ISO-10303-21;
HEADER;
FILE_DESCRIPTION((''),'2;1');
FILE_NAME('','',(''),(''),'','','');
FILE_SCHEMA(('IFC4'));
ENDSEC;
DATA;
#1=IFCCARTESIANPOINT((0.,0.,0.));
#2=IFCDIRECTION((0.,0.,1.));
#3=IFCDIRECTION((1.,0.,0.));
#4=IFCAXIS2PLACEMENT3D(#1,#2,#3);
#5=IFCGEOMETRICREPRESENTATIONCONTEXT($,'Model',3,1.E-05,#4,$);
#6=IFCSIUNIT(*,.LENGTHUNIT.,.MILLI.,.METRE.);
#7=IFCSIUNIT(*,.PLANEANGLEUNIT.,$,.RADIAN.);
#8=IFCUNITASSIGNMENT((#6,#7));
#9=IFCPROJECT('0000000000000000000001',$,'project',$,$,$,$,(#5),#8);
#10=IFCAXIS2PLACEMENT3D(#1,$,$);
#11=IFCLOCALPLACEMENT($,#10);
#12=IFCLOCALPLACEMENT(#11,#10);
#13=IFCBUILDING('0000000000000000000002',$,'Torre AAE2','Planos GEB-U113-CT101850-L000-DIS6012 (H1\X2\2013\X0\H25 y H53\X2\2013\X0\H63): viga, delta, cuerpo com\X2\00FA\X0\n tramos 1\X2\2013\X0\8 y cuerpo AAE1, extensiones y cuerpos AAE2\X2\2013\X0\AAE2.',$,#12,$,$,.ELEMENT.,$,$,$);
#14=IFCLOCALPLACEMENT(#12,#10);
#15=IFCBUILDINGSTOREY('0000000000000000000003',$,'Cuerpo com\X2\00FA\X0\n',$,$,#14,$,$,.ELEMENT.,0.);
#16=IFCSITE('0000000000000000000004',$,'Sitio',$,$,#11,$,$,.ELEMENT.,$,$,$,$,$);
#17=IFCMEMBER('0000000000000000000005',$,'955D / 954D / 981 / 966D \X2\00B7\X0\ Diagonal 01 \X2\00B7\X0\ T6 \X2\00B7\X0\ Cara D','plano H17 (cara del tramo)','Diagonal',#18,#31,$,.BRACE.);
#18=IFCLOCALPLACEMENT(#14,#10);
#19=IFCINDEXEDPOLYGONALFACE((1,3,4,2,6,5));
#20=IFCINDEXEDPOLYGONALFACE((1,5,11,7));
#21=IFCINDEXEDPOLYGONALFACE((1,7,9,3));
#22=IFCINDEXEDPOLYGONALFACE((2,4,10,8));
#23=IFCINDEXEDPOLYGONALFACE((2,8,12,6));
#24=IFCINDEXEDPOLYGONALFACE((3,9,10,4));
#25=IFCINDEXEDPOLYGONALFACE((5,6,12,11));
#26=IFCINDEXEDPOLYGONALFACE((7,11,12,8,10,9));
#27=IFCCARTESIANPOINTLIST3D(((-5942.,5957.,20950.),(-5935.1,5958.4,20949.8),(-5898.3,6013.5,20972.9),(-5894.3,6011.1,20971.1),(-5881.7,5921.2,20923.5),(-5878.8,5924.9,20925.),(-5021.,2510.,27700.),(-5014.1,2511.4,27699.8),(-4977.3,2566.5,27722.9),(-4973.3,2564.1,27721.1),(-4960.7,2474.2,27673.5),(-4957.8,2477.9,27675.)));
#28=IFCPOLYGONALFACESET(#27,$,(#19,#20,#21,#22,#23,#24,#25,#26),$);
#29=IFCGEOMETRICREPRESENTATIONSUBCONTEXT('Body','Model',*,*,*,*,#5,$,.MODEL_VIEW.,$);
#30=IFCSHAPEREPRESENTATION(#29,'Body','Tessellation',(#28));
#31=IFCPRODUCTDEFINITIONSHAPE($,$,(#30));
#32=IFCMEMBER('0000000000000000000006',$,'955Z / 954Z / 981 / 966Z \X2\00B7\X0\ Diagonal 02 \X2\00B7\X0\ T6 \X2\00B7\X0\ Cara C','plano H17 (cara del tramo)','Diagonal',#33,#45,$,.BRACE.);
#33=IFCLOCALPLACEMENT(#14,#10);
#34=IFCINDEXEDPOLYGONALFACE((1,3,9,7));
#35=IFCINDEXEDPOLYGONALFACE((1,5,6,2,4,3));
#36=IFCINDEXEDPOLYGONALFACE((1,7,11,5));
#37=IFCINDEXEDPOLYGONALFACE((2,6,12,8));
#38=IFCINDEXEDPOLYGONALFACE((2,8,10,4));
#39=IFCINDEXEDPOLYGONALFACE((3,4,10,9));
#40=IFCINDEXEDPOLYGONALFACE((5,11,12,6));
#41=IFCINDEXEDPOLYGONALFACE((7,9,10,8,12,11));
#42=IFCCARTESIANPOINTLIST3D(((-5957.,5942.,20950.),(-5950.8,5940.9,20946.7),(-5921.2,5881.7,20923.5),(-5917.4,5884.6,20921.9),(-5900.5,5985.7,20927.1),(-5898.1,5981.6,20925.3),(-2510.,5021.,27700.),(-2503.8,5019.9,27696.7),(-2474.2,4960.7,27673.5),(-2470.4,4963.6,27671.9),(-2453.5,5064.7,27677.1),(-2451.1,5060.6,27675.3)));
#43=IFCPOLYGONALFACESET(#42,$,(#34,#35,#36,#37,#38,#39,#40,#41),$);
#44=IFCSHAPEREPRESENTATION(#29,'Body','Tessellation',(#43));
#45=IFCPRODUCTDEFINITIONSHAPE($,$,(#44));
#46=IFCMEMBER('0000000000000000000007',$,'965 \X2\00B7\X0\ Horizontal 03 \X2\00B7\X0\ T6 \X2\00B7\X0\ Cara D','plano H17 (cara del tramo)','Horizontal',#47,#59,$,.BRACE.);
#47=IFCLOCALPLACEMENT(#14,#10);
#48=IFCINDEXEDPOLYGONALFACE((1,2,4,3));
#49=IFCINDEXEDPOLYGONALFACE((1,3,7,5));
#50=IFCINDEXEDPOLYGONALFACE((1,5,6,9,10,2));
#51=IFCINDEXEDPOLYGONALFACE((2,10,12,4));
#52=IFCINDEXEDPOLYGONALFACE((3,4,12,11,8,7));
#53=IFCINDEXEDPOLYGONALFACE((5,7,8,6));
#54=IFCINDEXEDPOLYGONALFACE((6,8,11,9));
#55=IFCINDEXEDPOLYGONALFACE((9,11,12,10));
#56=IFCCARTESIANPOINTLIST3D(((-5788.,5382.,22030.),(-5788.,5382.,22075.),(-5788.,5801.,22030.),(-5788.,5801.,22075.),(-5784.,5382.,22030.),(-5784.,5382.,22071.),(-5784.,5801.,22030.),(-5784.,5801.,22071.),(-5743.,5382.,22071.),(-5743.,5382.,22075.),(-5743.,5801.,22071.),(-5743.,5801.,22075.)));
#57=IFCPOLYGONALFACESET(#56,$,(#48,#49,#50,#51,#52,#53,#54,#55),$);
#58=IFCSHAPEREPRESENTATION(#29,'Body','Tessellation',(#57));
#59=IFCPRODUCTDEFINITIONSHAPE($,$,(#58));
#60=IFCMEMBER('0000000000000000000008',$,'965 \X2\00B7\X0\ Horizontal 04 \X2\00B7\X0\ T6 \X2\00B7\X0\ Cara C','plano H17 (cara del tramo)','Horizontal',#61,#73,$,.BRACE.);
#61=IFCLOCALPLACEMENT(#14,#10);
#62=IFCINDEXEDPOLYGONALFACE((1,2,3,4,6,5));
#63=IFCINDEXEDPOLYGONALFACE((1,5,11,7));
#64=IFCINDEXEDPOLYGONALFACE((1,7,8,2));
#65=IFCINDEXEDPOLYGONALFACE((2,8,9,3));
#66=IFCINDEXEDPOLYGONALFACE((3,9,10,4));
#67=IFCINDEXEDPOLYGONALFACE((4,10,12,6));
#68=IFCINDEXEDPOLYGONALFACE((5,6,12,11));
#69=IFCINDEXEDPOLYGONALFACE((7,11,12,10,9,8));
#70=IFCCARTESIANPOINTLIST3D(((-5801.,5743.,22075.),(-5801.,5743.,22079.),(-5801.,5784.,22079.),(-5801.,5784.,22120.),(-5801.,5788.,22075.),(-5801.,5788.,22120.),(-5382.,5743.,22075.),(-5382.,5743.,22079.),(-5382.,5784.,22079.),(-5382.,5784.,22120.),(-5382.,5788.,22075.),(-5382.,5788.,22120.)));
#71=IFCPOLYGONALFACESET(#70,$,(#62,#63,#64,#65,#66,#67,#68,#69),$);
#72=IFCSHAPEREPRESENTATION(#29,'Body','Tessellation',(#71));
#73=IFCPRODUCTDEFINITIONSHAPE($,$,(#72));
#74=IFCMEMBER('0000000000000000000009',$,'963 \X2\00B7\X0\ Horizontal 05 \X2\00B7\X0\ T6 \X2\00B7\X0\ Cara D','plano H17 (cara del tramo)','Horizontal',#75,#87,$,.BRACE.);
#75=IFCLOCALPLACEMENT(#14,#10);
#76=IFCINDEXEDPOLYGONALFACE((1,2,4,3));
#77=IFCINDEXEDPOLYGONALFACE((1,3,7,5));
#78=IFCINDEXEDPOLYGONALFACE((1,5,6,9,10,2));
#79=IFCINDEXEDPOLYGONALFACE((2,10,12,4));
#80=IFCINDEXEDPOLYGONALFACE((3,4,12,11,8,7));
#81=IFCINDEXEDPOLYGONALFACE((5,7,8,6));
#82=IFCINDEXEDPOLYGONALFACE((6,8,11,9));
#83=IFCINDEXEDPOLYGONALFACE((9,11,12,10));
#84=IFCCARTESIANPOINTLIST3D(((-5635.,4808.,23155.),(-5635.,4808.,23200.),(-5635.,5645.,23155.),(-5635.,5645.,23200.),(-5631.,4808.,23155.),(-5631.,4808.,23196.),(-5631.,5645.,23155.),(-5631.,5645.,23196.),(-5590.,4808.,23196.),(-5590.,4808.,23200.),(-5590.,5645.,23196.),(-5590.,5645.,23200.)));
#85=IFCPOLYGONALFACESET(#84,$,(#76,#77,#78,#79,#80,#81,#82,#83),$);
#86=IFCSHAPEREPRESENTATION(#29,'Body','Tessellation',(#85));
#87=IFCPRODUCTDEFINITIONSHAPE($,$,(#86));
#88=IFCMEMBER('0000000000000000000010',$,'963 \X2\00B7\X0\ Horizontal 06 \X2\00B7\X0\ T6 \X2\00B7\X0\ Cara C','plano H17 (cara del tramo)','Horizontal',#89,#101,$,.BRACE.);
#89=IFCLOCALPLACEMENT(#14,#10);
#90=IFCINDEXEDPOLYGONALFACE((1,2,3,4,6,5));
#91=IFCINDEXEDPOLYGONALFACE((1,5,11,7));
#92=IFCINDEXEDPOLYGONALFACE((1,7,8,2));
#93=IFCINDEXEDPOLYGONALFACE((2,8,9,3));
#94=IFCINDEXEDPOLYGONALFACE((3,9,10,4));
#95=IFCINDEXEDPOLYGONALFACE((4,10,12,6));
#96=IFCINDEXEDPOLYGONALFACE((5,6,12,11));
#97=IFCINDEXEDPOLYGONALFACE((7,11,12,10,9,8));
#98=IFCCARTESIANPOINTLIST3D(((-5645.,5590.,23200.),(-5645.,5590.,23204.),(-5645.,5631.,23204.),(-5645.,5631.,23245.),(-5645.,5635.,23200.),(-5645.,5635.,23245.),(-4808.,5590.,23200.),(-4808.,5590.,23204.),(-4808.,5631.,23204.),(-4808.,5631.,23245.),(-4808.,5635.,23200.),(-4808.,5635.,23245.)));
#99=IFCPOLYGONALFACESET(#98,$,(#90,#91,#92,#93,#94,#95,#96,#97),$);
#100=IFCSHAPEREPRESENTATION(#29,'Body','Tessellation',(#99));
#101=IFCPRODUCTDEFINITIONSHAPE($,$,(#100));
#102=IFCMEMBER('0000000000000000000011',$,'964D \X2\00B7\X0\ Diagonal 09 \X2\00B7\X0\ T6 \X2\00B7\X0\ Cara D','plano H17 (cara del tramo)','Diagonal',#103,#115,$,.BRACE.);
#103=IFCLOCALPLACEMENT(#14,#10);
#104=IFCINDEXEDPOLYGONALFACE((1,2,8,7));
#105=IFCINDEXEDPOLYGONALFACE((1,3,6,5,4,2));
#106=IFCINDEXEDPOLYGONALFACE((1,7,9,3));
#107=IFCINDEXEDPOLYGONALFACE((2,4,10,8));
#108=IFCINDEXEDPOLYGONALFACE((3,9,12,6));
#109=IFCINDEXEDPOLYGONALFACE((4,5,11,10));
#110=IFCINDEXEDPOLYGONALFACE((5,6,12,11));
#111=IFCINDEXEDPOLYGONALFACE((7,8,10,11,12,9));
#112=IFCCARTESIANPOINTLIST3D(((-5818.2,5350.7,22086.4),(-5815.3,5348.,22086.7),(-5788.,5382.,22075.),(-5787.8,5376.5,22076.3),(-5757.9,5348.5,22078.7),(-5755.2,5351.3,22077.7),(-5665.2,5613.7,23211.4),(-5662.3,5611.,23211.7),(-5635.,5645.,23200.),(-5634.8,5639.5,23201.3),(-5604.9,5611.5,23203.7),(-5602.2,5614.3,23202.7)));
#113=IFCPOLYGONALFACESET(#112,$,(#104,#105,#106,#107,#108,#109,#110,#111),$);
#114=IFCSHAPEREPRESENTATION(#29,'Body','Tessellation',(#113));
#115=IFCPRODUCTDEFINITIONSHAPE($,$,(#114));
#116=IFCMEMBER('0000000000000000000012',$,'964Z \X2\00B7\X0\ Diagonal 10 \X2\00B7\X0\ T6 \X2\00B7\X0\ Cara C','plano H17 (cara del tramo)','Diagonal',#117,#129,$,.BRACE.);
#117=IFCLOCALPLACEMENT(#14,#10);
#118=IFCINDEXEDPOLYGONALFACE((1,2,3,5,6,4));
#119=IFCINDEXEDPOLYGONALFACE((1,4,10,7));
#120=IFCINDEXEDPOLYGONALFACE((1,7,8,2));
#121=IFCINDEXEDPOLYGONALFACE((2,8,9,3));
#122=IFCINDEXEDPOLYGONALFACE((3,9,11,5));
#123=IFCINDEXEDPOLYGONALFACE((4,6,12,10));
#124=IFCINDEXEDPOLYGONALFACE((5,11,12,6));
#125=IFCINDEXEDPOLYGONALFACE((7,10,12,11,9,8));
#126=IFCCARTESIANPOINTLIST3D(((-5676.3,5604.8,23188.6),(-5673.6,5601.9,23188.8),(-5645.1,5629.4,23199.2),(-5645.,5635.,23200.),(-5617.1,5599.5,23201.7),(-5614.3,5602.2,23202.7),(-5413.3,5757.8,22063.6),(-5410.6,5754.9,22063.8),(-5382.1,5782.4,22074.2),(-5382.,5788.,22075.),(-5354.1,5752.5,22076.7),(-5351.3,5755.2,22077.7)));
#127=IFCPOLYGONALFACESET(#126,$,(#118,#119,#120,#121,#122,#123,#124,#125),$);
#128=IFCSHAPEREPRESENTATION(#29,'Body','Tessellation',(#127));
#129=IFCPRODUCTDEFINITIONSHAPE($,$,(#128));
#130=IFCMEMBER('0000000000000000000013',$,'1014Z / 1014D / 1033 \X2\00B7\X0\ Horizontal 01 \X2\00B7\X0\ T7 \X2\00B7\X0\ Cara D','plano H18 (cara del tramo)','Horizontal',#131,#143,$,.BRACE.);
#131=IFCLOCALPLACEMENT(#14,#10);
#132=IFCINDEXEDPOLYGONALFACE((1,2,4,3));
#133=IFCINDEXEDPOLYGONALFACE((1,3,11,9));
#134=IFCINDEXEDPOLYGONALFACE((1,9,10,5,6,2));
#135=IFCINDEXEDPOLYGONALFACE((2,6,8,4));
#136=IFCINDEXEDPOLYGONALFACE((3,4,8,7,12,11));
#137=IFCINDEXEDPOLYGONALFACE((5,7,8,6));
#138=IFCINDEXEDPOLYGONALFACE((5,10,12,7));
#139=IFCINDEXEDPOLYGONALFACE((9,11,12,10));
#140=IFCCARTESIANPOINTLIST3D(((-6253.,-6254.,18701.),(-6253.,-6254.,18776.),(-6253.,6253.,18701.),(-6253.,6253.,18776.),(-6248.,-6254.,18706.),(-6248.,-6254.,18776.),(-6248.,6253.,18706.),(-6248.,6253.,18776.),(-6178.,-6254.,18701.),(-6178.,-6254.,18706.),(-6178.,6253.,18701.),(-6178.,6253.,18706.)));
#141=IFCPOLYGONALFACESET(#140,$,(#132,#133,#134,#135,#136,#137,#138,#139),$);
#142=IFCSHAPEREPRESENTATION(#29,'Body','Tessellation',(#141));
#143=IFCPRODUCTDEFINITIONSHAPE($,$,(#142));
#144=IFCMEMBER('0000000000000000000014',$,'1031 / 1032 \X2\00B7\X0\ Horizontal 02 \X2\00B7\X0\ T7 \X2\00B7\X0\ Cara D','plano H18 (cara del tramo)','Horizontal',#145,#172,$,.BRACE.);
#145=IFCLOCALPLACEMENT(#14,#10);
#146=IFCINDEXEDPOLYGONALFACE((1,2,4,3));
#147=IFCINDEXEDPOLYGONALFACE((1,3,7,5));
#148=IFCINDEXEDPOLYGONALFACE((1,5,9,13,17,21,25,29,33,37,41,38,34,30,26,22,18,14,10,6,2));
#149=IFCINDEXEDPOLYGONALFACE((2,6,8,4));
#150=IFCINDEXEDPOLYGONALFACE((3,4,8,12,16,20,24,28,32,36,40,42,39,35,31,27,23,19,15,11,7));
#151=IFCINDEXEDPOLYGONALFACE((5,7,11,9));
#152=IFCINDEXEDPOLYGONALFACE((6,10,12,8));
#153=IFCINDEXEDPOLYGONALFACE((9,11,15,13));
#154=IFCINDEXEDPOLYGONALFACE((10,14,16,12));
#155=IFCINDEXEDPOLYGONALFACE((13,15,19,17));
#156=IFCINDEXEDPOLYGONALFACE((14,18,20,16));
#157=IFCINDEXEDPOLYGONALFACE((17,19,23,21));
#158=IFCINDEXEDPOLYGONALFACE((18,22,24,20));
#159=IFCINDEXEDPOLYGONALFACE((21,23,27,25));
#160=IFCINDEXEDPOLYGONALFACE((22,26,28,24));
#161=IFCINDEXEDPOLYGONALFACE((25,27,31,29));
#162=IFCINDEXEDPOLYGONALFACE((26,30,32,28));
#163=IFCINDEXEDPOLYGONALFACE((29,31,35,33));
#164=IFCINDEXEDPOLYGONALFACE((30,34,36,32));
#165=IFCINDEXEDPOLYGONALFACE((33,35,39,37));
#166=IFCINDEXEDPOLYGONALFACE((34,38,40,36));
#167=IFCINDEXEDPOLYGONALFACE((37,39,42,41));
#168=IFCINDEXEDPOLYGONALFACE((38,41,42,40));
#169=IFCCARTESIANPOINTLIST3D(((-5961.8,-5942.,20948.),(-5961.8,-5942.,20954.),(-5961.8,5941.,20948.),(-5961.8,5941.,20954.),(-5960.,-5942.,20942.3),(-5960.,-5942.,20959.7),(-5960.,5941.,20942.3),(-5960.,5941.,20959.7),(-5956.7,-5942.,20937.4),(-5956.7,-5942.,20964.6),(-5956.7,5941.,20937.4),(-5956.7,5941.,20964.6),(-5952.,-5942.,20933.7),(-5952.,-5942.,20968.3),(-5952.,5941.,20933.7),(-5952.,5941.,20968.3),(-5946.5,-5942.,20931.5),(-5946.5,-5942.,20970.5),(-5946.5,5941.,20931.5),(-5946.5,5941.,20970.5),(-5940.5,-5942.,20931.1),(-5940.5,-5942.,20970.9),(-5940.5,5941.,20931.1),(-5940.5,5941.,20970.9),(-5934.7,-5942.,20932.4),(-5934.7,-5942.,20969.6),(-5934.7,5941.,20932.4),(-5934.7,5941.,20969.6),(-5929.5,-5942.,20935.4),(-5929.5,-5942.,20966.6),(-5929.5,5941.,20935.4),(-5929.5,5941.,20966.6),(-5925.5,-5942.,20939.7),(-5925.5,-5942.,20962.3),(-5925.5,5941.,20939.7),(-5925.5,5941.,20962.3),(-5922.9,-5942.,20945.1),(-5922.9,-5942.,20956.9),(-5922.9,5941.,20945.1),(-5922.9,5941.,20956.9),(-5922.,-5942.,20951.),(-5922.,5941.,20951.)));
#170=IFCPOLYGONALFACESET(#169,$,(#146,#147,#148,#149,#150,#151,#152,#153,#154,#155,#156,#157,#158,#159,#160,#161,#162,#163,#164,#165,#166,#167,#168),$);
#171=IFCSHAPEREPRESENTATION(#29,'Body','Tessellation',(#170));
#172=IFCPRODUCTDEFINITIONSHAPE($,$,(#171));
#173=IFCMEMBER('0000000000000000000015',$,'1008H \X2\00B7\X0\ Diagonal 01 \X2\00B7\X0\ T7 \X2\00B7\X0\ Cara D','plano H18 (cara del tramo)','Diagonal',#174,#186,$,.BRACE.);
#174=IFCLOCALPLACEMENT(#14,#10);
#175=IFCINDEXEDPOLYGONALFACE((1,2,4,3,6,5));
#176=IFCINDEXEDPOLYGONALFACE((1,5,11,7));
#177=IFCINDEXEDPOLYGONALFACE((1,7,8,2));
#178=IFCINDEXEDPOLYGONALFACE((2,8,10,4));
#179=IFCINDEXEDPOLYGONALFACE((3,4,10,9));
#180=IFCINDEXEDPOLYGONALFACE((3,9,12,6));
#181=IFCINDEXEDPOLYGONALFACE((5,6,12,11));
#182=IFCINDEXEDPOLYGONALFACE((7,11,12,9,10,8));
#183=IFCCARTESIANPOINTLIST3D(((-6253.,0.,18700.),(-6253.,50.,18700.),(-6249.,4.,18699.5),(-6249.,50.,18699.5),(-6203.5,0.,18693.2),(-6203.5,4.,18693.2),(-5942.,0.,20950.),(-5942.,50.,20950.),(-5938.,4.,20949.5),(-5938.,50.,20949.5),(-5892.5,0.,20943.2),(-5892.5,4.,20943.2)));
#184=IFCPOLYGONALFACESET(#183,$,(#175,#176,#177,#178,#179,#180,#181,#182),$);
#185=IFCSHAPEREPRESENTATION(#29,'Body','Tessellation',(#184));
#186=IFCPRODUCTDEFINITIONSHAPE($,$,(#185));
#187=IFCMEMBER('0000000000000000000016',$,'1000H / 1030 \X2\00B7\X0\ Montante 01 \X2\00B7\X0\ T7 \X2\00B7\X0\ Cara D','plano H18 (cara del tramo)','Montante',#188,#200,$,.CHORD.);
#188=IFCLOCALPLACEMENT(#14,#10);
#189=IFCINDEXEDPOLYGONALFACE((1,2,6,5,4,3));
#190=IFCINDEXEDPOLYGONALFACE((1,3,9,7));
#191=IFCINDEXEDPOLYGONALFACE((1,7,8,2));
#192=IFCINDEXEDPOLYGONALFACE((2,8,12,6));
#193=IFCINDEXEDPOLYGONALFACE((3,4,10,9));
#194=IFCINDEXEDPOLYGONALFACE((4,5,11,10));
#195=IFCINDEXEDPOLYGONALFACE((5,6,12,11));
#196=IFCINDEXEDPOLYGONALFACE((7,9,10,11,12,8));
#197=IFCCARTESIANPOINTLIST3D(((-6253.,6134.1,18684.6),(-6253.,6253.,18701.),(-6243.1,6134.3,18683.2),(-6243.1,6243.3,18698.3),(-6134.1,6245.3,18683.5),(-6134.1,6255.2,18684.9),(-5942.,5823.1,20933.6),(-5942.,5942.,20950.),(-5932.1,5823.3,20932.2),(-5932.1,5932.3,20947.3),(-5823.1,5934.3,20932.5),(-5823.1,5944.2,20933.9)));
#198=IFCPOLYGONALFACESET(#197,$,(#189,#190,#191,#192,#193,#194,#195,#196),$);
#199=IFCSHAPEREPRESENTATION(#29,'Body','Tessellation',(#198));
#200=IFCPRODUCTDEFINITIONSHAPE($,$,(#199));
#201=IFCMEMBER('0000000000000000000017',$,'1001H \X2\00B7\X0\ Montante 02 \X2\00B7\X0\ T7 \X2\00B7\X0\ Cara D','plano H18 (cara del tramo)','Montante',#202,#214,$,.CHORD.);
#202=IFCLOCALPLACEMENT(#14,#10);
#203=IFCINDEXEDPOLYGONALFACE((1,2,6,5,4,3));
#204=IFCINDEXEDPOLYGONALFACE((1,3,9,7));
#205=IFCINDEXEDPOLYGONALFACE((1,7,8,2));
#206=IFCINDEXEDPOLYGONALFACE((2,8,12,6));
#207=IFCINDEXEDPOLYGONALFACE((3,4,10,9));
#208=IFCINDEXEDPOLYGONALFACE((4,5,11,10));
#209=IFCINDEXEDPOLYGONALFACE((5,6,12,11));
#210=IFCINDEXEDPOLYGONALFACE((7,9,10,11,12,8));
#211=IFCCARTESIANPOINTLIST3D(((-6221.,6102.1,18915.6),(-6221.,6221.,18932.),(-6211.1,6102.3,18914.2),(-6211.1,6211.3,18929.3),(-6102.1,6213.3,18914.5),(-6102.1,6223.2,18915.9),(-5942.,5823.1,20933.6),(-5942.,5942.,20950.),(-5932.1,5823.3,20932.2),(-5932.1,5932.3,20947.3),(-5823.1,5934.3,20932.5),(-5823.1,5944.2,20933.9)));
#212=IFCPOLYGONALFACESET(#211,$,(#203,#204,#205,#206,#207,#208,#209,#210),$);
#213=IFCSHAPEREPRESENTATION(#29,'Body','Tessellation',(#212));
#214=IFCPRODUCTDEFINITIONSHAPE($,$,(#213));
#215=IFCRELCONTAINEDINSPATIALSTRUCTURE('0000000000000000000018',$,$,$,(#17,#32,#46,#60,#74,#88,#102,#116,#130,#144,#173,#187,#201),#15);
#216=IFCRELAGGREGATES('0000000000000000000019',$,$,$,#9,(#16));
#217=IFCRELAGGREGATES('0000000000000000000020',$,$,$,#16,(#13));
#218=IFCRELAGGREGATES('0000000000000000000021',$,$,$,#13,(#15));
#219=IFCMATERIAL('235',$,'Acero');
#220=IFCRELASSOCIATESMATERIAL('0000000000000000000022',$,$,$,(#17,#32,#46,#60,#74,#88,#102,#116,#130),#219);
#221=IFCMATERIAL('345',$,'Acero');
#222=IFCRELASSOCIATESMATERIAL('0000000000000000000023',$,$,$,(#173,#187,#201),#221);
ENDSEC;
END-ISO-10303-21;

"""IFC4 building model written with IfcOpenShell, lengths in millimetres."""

from ifc_helpers import new_model, si_unit, frame, frame_2d, origin, origin_with_axes, place, context, subcontext, project, spatial, circle, l_section, extrude, material, element, save


model = new_model("IFC4")

# Units and contexts
model_context = context("Model", 3, precision=1e-05, world=origin_with_axes())
body_context = subcontext(model_context, "Body", "Model", "MODEL_VIEW")
ifc_project = project(units=[si_unit("LENGTHUNIT", "METRE", prefix="MILLI"), si_unit("PLANEANGLEUNIT", "RADIAN")], contexts=[model_context])

# Site, building, storey
site_placement = place(None, origin())
site = spatial("IfcSite", under=ifc_project, at=site_placement, Name="Sitio", CompositionType="ELEMENT")
building_placement = place(site_placement, origin())
building = spatial("IfcBuilding", under=site, at=building_placement, Name="Torre AAE2", Description="Planos GEB-U113-CT101850-L000-DIS6012 (H1–H25 y H53–H63): viga, delta, cuerpo común tramos 1–8 y cuerpo AAE1, extensiones y cuerpos AAE2–AAE2.", CompositionType="ELEMENT")
storey_placement = place(building_placement, origin())
storey = spatial("IfcBuildingStorey", under=building, at=storey_placement, Name="Cuerpo común", CompositionType="ELEMENT", Elevation=0.0)

# Members
ifc_material_1 = material(Name="235", Category="Acero")
for number, where, z_axis, x_axis, name in (
    (1, (-5942.0, 5957.0, 20950.0), (0.120629, -0.451476, 0.884092), (0.804164, -0.477732, -0.353685), "955D / 954D / 981 / 966D · Diagonal 01 · T6 · Cara D"),
    (2, (-5957.0, 5942.0, 20950.0), (0.451476, -0.120629, 0.884092), (0.477732, -0.804164, -0.353685), "955Z / 954Z / 981 / 966Z · Diagonal 02 · T6 · Cara C"),
):
    element("IfcMember", number, at=place(storey_placement, frame(where, z_axis=z_axis, x_axis=x_axis)), inside=storey, material=ifc_material_1, Name=name, Description="plano H17 (cara del tramo)", ObjectType="Diagonal", PredefinedType="BRACE", context=body_context, shape_type="SweptSolid", body=[
        extrude(l_section(Depth=75.0, Width=75.0, Thickness=5.0, at=frame_2d((37.5, 37.5))), None, (0.0, 0.0, 1.0), 7635.0),
    ])
for number, where, z_axis, x_axis, name in (
    (3, (-5788.0, 5382.0, 22075.0), (0.0, 1.0, 0.0), (1.0, 0.0, 0.0), "965 · Horizontal 03 · T6 · Cara D"),
    (4, (-5382.0, 5788.0, 22075.0), (-1.0, 0.0, 0.0), (0.0, -1.0, 0.0), "965 · Horizontal 04 · T6 · Cara C"),
):
    element("IfcMember", number, at=place(storey_placement, frame(where, z_axis=z_axis, x_axis=x_axis)), inside=storey, material=ifc_material_1, Name=name, Description="plano H17 (cara del tramo)", ObjectType="Horizontal", PredefinedType="BRACE", context=body_context, shape_type="SweptSolid", body=[
        extrude(l_section(Depth=45.0, Width=45.0, Thickness=4.0, at=frame_2d((22.5, 22.5))), None, (0.0, 0.0, 1.0), 419.0),
    ])
for number, where, z_axis, x_axis, name in (
    (5, (-5635.0, 4808.0, 23200.0), (0.0, 1.0, 0.0), (1.0, 0.0, 0.0), "963 · Horizontal 05 · T6 · Cara D"),
    (6, (-4808.0, 5635.0, 23200.0), (-1.0, 0.0, 0.0), (0.0, -1.0, 0.0), "963 · Horizontal 06 · T6 · Cara C"),
):
    element("IfcMember", number, at=place(storey_placement, frame(where, z_axis=z_axis, x_axis=x_axis)), inside=storey, material=ifc_material_1, Name=name, Description="plano H17 (cara del tramo)", ObjectType="Horizontal", PredefinedType="BRACE", context=body_context, shape_type="SweptSolid", body=[
        extrude(l_section(Depth=45.0, Width=45.0, Thickness=4.0, at=frame_2d((22.5, 22.5))), None, (0.0, 0.0, 1.0), 837.0),
    ])
for number, where, z_axis, x_axis, name in (
    (7, (-5635.0, 5645.0, 23200.0), (-0.131283, -0.22567, -0.965318), (0.729059, -0.681795, 0.060236), "964D · Diagonal 09 · T6 · Cara D"),
    (8, (-5645.0, 5635.0, 23200.0), (0.22567, 0.131283, -0.965318), (0.681795, -0.729059, 0.060236), "964Z · Diagonal 10 · T6 · Cara C"),
):
    element("IfcMember", number, at=place(storey_placement, frame(where, z_axis=z_axis, x_axis=x_axis)), inside=storey, material=ifc_material_1, Name=name, Description="plano H17 (cara del tramo)", ObjectType="Diagonal", PredefinedType="BRACE", context=body_context, shape_type="SweptSolid", body=[
        extrude(l_section(Depth=45.0, Width=45.0, Thickness=4.0, at=frame_2d((22.5, 22.5))), None, (0.0, 0.0, 1.0), 1165.4),
    ])
member_1_placement = place(storey_placement, frame((-6253.0, 6253.0, 18701.0), z_axis=(0.0, -1.0, 0.0), x_axis=(1.0, 0.0, 0.0)))
element("IfcMember", 9, at=member_1_placement, inside=storey, material=ifc_material_1, Name="1014Z / 1014D / 1033 · Horizontal 01 · T7 · Cara D", Description="plano H18 (cara del tramo)", ObjectType="Horizontal", PredefinedType="BRACE", context=body_context, shape_type="SweptSolid", body=[
    extrude(l_section(Depth=75.0, Width=75.0, Thickness=5.0, at=frame_2d((37.5, 37.5))), None, (0.0, 0.0, 1.0), 12507.0),
])
member_2_placement = place(storey_placement, frame((-5942.0, 5941.0, 20951.0), z_axis=(0.0, -1.0, 0.0), x_axis=(1.0, 0.0, 0.0)))
element("IfcMember", 10, at=member_2_placement, inside=storey, Name="1031 / 1032 · Horizontal 02 · T7 · Cara D", Description="plano H18 (cara del tramo)", ObjectType="Horizontal", PredefinedType="BRACE", context=body_context, shape_type="SweptSolid", body=[
    extrude(circle(Radius=20.0), None, (0.0, 0.0, 1.0), 11883.0),
])
ifc_material_2 = material(Name="345", Category="Acero")
member_3_placement = place(storey_placement, frame((-6253.0, 0.0, 18700.0), z_axis=(0.13692, 0.0, 0.990582), x_axis=(0.990582, 0.0, -0.13692)))
element("IfcMember", 11, at=member_3_placement, inside=storey, material=ifc_material_2, Name="1008H · Diagonal 01 · T7 · Cara D", Description="plano H18 (cara del tramo)", ObjectType="Diagonal", PredefinedType="BRACE", context=body_context, shape_type="SweptSolid", body=[
    extrude(l_section(Depth=50.0, Width=50.0, Thickness=4.0, at=frame_2d((25.0, 25.0))), None, (0.0, 0.0, 1.0), 2271.4),
])
member_4_placement = place(storey_placement, frame((-5942.0, 5942.0, 20950.0), z_axis=(-0.135713, 0.135713, -0.981409), x_axis=(0.990748, 0.01859, -0.134434)))
element("IfcMember", 12, at=member_4_placement, inside=storey, material=ifc_material_2, Name="1000H / 1030 · Montante 01 · T7 · Cara D", Description="plano H18 (cara del tramo)", ObjectType="Montante", PredefinedType="CHORD", context=body_context, shape_type="SweptSolid", body=[
    extrude(l_section(Depth=120.0, Width=120.0, Thickness=10.0, at=frame_2d((60.0, 60.0))), None, (0.0, 0.0, 1.0), 2291.6),
])
member_5_placement = place(storey_placement, frame((-5942.0, 5942.0, 20950.0), z_axis=(-0.135686, 0.135686, -0.981417), x_axis=(0.990752, 0.018583, -0.134408)))
element("IfcMember", 13, at=member_5_placement, inside=storey, material=ifc_material_2, Name="1001H · Montante 02 · T7 · Cara D", Description="plano H18 (cara del tramo)", ObjectType="Montante", PredefinedType="CHORD", context=body_context, shape_type="SweptSolid", body=[
    extrude(l_section(Depth=120.0, Width=120.0, Thickness=10.0, at=frame_2d((60.0, 60.0))), None, (0.0, 0.0, 1.0), 2056.2),
])

save(model, "model.ifc")
